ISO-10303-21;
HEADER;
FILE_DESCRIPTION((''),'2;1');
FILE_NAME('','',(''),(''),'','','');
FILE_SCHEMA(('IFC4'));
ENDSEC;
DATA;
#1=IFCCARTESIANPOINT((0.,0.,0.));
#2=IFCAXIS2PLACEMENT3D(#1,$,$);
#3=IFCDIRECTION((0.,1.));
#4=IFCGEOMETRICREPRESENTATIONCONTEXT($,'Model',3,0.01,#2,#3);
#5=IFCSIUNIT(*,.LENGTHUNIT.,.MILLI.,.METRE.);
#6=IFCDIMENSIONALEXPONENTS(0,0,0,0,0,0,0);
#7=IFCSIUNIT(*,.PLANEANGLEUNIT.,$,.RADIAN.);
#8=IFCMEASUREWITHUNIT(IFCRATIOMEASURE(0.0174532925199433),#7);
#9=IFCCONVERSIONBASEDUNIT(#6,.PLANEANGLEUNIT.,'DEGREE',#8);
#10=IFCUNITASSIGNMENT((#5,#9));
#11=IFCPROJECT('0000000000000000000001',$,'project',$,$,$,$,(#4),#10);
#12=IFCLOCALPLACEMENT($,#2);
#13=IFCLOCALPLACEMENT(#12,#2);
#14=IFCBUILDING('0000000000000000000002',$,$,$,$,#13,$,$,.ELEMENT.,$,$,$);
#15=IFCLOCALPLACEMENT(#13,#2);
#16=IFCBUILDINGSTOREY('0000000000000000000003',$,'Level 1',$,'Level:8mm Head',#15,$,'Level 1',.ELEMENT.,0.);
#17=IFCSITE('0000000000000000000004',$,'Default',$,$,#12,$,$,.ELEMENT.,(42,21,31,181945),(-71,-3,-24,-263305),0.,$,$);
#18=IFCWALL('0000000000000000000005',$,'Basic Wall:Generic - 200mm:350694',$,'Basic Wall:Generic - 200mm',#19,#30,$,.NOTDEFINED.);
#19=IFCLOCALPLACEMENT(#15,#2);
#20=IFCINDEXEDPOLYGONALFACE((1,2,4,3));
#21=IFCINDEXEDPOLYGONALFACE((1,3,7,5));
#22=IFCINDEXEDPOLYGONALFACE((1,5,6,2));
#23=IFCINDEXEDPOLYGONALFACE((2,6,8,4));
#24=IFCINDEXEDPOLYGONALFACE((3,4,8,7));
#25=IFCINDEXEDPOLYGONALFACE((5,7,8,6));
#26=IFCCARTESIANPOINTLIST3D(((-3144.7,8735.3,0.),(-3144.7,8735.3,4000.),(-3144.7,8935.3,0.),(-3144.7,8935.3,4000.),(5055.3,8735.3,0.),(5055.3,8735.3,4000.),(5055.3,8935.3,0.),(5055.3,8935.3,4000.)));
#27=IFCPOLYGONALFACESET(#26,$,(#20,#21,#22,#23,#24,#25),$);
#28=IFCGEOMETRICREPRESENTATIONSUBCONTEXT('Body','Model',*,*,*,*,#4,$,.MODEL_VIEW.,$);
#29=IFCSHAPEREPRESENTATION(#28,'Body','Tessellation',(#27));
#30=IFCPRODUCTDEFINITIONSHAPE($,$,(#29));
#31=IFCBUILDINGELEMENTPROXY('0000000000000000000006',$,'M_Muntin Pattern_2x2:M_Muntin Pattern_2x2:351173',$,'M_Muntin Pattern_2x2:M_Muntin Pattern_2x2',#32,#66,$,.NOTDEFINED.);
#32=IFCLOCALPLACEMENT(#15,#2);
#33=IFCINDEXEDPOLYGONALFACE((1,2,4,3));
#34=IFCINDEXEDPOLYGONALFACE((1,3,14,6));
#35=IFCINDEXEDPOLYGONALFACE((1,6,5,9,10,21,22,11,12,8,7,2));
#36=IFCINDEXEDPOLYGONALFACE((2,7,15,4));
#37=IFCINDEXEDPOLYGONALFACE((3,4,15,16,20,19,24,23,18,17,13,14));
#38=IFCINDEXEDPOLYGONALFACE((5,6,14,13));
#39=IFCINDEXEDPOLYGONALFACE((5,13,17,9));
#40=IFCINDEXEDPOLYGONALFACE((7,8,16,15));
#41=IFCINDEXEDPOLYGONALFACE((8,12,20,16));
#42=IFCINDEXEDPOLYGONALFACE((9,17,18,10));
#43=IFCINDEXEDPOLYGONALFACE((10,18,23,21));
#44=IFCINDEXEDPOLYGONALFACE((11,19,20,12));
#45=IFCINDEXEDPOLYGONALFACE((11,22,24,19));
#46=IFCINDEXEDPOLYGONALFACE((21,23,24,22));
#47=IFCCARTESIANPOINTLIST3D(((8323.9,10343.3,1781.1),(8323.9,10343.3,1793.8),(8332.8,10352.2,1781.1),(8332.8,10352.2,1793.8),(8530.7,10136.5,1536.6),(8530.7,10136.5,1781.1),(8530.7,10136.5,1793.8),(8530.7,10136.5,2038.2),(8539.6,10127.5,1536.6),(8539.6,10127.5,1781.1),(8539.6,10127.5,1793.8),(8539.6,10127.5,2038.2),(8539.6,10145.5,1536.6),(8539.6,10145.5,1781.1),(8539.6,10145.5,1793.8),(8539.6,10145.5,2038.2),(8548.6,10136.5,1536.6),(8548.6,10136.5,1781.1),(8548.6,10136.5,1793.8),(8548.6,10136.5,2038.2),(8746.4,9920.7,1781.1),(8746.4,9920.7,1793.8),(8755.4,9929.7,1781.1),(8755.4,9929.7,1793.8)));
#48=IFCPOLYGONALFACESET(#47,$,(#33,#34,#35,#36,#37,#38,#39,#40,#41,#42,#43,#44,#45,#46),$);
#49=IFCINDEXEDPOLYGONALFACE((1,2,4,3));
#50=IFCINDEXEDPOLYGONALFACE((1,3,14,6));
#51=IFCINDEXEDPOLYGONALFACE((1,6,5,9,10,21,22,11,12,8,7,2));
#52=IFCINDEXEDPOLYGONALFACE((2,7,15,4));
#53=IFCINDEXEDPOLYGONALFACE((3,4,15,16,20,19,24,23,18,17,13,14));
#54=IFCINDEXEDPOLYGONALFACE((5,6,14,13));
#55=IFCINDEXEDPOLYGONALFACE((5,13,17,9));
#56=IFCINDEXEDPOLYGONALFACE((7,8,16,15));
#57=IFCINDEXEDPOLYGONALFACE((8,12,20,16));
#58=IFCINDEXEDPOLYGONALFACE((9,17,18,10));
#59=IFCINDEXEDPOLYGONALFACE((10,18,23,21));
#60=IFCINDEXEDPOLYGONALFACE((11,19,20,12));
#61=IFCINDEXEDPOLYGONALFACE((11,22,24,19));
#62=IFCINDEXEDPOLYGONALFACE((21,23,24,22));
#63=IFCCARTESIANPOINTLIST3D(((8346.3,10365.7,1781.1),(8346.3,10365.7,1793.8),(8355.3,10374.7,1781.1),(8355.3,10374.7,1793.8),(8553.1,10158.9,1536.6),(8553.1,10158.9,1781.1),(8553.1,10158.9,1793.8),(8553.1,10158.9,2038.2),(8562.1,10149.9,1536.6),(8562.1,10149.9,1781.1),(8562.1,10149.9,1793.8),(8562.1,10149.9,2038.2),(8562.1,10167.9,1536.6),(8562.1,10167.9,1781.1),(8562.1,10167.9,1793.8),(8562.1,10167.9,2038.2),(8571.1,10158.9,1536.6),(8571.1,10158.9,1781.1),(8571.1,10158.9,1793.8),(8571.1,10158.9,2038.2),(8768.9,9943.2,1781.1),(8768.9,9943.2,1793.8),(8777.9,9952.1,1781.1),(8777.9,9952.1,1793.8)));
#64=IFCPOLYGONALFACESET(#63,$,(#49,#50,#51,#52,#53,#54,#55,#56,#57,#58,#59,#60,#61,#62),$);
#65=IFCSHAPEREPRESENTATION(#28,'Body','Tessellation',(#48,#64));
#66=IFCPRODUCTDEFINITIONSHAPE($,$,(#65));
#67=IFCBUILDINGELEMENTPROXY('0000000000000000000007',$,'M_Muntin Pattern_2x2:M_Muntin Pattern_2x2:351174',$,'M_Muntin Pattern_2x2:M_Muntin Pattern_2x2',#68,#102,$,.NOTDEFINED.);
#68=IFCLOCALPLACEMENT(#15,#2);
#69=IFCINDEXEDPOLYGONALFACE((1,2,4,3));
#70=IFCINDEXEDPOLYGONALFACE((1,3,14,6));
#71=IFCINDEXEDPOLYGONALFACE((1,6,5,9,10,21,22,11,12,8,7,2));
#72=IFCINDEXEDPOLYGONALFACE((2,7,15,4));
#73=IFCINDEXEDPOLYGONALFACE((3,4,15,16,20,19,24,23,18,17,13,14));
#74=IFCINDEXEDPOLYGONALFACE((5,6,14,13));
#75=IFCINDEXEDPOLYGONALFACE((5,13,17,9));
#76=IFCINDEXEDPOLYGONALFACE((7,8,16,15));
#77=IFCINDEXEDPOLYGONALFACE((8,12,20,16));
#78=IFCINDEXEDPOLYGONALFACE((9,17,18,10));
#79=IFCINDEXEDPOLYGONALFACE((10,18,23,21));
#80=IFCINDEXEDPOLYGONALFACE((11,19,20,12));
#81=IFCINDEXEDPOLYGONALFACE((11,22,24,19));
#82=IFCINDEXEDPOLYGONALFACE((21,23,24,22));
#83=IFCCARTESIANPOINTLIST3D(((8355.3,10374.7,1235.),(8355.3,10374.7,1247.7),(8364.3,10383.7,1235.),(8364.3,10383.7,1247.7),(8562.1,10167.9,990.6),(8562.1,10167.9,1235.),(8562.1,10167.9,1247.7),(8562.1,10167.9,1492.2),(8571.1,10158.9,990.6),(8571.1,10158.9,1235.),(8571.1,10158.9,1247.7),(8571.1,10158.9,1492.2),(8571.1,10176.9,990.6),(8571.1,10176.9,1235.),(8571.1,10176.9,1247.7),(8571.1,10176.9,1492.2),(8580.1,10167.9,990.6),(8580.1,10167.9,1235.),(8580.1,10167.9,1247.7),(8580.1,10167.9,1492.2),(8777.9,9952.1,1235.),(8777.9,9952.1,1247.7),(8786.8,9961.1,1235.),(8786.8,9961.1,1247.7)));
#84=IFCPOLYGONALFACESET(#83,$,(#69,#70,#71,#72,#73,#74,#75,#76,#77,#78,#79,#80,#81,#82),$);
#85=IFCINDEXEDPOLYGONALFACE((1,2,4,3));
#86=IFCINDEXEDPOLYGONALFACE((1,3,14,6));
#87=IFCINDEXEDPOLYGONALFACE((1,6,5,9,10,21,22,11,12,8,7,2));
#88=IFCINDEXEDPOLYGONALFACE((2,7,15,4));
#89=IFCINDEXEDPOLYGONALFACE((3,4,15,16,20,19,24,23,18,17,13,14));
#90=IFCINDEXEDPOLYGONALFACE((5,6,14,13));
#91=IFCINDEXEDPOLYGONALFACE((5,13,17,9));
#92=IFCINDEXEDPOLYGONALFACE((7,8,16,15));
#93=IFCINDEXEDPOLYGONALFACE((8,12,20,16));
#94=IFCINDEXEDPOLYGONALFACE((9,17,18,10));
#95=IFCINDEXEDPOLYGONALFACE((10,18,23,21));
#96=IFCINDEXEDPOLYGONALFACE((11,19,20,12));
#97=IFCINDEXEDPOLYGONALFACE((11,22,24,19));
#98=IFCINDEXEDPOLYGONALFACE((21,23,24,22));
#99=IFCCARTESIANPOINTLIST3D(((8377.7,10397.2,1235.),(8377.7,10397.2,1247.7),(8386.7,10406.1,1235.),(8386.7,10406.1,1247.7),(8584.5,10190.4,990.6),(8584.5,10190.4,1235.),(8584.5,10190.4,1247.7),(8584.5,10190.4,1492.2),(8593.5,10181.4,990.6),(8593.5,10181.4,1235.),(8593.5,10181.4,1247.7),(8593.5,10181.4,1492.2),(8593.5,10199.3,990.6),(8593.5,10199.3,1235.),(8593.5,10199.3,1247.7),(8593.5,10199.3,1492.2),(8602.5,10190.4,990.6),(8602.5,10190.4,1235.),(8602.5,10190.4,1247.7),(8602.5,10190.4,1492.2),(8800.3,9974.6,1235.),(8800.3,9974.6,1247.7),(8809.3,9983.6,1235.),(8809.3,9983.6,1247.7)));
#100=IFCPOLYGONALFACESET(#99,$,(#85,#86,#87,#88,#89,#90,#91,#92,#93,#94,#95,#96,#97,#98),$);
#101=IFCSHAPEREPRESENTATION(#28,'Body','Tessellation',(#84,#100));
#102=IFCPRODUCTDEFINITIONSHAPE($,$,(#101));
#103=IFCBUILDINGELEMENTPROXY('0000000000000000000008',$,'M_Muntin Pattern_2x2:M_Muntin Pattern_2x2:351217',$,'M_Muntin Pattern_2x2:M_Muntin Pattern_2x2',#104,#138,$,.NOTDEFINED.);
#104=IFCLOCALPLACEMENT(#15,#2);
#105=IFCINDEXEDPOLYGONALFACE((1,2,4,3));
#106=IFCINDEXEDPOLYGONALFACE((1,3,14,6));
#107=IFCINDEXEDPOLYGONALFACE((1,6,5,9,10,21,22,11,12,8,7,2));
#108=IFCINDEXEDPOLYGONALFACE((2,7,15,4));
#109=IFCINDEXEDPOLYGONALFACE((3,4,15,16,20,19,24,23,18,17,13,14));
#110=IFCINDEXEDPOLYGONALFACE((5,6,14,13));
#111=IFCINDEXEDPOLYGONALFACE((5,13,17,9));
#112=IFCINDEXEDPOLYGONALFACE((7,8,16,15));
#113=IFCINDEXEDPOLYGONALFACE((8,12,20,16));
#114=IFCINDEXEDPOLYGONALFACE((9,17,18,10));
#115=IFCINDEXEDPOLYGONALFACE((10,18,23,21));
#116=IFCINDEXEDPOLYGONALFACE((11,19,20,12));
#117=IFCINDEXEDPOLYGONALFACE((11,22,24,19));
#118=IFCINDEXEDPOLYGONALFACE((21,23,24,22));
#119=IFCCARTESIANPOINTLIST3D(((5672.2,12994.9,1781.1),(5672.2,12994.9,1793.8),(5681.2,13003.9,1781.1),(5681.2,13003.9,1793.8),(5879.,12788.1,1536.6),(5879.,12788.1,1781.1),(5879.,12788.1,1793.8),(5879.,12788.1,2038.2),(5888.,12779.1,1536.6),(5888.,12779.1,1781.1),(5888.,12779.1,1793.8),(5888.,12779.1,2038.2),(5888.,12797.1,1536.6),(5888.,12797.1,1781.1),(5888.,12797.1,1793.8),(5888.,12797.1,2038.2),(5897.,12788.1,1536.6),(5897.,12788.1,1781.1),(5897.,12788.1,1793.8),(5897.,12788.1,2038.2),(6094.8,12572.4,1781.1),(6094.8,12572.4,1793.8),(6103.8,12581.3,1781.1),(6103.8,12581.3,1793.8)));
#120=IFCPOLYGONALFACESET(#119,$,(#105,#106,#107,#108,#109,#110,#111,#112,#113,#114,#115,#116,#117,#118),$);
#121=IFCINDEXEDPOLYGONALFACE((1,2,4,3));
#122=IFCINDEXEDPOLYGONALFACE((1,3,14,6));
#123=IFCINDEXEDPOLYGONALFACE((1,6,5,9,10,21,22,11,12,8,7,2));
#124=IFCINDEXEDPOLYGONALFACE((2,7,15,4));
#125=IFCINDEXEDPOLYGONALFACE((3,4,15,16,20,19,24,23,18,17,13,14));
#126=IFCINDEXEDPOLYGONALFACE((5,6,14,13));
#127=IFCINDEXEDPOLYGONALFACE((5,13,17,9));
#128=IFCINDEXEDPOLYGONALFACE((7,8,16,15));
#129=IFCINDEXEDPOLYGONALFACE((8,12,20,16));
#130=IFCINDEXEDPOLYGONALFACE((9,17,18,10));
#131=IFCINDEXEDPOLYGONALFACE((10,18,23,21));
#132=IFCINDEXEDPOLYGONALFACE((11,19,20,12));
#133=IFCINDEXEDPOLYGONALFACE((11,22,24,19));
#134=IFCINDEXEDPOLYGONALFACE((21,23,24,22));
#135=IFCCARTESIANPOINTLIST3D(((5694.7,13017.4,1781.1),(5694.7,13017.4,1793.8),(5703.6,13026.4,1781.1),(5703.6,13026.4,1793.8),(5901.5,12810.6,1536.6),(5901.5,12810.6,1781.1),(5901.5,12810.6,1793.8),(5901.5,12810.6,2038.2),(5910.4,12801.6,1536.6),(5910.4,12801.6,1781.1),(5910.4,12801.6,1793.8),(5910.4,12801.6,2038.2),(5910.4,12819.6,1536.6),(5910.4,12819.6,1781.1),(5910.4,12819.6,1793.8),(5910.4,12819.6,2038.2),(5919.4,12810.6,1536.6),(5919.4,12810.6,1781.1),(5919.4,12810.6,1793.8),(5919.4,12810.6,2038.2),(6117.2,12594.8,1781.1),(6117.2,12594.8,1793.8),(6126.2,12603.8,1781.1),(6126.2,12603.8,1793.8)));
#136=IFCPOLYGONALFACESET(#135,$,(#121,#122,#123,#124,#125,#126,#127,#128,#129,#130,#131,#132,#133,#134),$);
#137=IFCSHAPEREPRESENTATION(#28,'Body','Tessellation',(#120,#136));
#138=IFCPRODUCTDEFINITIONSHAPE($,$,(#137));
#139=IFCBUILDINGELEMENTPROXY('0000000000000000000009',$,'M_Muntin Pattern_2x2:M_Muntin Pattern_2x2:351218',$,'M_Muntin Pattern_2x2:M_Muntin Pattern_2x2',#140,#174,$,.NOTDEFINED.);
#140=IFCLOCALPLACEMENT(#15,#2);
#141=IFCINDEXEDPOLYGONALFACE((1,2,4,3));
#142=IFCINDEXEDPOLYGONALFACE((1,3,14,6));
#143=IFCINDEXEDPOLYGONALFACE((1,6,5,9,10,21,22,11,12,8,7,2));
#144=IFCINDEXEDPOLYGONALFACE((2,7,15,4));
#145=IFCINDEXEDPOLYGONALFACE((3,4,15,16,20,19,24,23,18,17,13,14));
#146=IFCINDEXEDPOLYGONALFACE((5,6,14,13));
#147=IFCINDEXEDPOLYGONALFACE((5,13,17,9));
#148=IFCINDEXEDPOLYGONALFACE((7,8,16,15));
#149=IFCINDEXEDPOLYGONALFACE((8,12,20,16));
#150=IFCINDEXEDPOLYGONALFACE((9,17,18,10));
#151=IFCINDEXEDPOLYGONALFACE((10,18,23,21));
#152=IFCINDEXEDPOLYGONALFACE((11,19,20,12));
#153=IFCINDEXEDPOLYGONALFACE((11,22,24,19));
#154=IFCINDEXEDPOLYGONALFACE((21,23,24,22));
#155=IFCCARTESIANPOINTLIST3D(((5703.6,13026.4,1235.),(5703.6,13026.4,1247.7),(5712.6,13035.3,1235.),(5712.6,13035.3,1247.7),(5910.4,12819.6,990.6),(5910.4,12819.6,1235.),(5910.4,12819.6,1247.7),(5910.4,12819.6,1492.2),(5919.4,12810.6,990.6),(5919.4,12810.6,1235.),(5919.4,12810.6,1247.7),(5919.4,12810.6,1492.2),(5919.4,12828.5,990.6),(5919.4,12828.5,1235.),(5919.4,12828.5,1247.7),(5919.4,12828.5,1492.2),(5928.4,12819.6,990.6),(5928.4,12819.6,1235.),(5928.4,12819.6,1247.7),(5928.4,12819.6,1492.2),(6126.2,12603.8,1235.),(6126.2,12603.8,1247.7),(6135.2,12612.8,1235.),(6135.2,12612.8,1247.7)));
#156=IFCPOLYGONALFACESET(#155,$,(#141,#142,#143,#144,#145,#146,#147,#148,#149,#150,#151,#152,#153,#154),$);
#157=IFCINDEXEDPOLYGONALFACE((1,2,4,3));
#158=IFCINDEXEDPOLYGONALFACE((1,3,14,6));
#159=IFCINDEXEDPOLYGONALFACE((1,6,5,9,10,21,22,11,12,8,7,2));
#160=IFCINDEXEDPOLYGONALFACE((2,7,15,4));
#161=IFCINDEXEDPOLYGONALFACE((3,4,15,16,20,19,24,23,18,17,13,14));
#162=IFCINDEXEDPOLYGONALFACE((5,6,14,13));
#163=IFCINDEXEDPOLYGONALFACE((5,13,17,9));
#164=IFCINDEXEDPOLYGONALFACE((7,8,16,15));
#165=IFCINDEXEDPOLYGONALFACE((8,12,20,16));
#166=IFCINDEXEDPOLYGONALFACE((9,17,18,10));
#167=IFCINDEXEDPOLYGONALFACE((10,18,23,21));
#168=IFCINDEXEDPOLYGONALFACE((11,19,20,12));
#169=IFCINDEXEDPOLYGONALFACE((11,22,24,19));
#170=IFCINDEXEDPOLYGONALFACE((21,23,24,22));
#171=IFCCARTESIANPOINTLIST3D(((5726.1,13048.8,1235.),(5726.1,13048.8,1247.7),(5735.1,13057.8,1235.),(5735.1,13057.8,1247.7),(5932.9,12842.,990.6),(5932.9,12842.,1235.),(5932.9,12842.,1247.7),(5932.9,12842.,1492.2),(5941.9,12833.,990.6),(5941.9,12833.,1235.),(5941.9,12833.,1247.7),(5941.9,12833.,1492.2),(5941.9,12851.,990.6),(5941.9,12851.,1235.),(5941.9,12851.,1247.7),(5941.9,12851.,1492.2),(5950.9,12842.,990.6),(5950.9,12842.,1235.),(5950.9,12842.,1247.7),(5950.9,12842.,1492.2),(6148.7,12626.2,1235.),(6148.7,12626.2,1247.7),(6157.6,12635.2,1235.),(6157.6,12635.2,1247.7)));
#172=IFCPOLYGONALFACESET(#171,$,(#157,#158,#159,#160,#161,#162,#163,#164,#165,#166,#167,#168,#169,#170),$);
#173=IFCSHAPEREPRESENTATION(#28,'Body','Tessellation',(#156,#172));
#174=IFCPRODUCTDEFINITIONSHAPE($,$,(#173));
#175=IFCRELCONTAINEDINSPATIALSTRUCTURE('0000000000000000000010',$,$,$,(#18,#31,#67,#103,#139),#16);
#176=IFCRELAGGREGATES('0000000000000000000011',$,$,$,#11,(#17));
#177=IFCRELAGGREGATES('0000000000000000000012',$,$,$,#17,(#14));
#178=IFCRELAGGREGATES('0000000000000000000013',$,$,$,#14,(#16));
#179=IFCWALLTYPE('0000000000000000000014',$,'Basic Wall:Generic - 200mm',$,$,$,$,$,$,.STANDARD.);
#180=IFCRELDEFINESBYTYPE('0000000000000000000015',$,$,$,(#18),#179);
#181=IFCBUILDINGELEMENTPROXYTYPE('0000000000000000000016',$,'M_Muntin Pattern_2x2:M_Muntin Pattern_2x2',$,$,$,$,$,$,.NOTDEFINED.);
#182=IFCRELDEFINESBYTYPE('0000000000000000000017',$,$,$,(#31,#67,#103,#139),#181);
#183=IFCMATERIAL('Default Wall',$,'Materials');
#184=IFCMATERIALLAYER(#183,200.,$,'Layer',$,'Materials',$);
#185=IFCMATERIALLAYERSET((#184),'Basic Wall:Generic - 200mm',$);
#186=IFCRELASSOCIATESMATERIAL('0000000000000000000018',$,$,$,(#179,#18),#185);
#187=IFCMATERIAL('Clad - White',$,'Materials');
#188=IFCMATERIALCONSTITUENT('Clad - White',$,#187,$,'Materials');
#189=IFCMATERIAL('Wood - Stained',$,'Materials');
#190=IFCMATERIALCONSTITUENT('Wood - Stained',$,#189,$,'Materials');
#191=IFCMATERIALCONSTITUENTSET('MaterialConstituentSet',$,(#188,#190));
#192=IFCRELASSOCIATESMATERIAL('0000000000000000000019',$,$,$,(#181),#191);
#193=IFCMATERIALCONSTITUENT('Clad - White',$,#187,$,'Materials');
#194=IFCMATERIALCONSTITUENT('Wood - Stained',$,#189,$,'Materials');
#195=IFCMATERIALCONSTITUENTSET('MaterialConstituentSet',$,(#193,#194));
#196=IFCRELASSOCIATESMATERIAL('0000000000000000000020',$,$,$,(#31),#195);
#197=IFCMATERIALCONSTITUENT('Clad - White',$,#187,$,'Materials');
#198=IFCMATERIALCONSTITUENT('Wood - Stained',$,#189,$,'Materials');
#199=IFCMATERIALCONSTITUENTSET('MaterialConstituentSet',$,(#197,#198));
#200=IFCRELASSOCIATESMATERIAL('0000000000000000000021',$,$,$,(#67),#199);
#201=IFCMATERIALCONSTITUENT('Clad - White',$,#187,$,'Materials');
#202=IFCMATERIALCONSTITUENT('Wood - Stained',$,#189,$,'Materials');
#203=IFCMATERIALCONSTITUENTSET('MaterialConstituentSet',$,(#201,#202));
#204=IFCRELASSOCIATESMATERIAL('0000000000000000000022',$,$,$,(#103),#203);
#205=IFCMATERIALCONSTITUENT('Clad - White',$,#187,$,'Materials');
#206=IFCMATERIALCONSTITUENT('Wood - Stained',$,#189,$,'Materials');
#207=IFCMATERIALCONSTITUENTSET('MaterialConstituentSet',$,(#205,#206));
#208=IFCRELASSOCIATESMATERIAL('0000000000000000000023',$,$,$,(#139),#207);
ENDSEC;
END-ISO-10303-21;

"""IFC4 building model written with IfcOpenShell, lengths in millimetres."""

from ifc_helpers import new_model, entity, si_unit, converted_unit, direction, frame, frame_2d, origin, place, context, subcontext, project, spatial, polyline, rectangle, outline, extrude, source, transform, mapped, material, layer, layer_set, layer_usage, constituent, constituent_set, type_object, type_shapes, element, save


model = new_model("IFC4")

# Units and contexts
model_context = context("Model", 3, precision=0.01, world=origin(), true_north=direction((0.0, 1.0)))
body_context = subcontext(model_context, "Body", "Model", "MODEL_VIEW")
ifc_project = project(units=[si_unit("LENGTHUNIT", "METRE", prefix="MILLI"), converted_unit("PLANEANGLEUNIT", "DEGREE", entity("IfcRatioMeasure", 0.0174532925199433), si_unit("PLANEANGLEUNIT", "RADIAN"), dimensions=[0, 0, 0, 0, 0, 0, 0])], contexts=[model_context])

# Site, building, storey
site_placement = place(None, origin())
site = spatial("IfcSite", under=ifc_project, at=site_placement, Name="Default", CompositionType="ELEMENT", RefLatitude=(42, 21, 31, 181945), RefLongitude=(-71, -3, -24, -263305), RefElevation=0.0)
building_placement = place(site_placement, origin())
building = spatial("IfcBuilding", under=site, at=building_placement, CompositionType="ELEMENT")
storey_placement = place(building_placement, origin())
storey = spatial("IfcBuildingStorey", under=building, at=storey_placement, Name="Level 1", ObjectType="Level:8mm Head", LongName="Level 1", CompositionType="ELEMENT", Elevation=0.0)

# Shared definitions
ifc_material_1 = material(Name="Default Wall", Category="Materials")
ifc_layer = layer(ifc_material_1, 200.0, Name="Layer", Category="Materials")
ifc_layer_set = layer_set([ifc_layer], Name="Basic Wall:Generic - 200mm")
wall_type = type_object("IfcWallType", Name="Basic Wall:Generic - 200mm", PredefinedType="STANDARD", material=ifc_layer_set)
ifc_material_2 = material(Name="Wood - Stained", Category="Materials")

# Wall
ifc_layer_usage_1 = layer_usage(ifc_layer_set, "AXIS2", "NEGATIVE", 100.0)
wall_1_placement = place(storey_placement, frame((5055.3, 8835.3, 0.0), z_axis=(0.0, 0.0, 1.0), x_axis=(-1.0, 0.0, 0.0)))
element("IfcWall", 1, at=wall_1_placement, inside=storey, type_object=wall_type, material=ifc_layer_usage_1, Name="Basic Wall:Generic - 200mm:350694", ObjectType="Basic Wall:Generic - 200mm", PredefinedType="NOTDEFINED", context=body_context, shape_type="SweptSolid", body=[
    extrude(rectangle(XDim=8200.0, YDim=200.0, at=frame_2d((4100.0, 0.0), x_axis=(-1.0, 0.0))), origin(), (0.0, 0.0, 1.0), 4000.0),
])

# Building element proxies
ifc_material_3 = material(Name="Clad - White", Category="Materials")
ifc_constituent_1 = constituent(ifc_material_3, Name="Clad - White", Category="Materials")
ifc_constituent_2 = constituent(ifc_material_2, Name="Wood - Stained", Category="Materials")
ifc_constituent_set_1 = constituent_set(constituents=[ifc_constituent_1, ifc_constituent_2], Name="MaterialConstituentSet")
ifc_constituent_3 = constituent(ifc_material_3, Name="Clad - White", Category="Materials")
ifc_constituent_4 = constituent(ifc_material_2, Name="Wood - Stained", Category="Materials")
ifc_constituent_set_2 = constituent_set(constituents=[ifc_constituent_3, ifc_constituent_4], Name="MaterialConstituentSet")
building_element_proxy_type_1 = type_object("IfcBuildingElementProxyType", Name="M_Muntin Pattern_2x2:M_Muntin Pattern_2x2", PredefinedType="NOTDEFINED", material=ifc_constituent_set_2)
shared_shape_1 = source(origin(), body_context, "Body", "SweptSolid", [
    extrude(outline(polyline([(6.4, -6.4), (250.8, -6.4), (250.8, 6.3), (6.4, 6.3), (6.4, 298.8), (-6.3, 298.8), (-6.3, 6.3), (-250.8, 6.3), (-250.8, -6.4), (-6.3, -6.4), (-6.3, -298.8), (6.4, -298.8), (6.4, -6.4)])), frame((0.0, 9.5, 250.8), z_axis=(0.0, 1.0, 0.0), x_axis=(0.0, 0.0, 1.0)), (0.0, 0.0, 1.0), 12.7),
    extrude(outline(polyline([(6.4, -6.4), (250.8, -6.4), (250.8, 6.3), (6.4, 6.3), (6.4, 298.8), (-6.3, 298.8), (-6.3, 6.3), (-250.8, 6.3), (-250.8, -6.4), (-6.3, -6.4), (-6.3, -298.8), (6.4, -298.8), (6.4, -6.4)])), frame((0.0, -22.2, 250.8), z_axis=(0.0, 1.0, 0.0), x_axis=(0.0, 0.0, 1.0)), (0.0, 0.0, 1.0), 12.7),
])
type_shapes(building_element_proxy_type_1, [shared_shape_1])
proxy_1_placement = place(storey_placement, frame((8550.9, 10147.7, 1536.6), z_axis=(0.0, 0.0, 1.0), x_axis=(-0.707107, 0.707107, 0.0)))
element("IfcBuildingElementProxy", 2, at=proxy_1_placement, inside=storey, type_object=building_element_proxy_type_1, material=ifc_constituent_set_1, Name="M_Muntin Pattern_2x2:M_Muntin Pattern_2x2:351173", ObjectType="M_Muntin Pattern_2x2:M_Muntin Pattern_2x2", PredefinedType="NOTDEFINED", context=body_context, shape_type="MappedRepresentation", body=[
    mapped(shared_shape_1, transform((0.0, 0.0, 0.0), scale=1.0)),
])
ifc_constituent_5 = constituent(ifc_material_3, Name="Clad - White", Category="Materials")
ifc_constituent_6 = constituent(ifc_material_2, Name="Wood - Stained", Category="Materials")
ifc_constituent_set_3 = constituent_set(constituents=[ifc_constituent_5, ifc_constituent_6], Name="MaterialConstituentSet")
proxy_2_placement = place(storey_placement, frame((8582.3, 10179.1, 990.6), z_axis=(0.0, 0.0, 1.0), x_axis=(-0.707107, 0.707107, 0.0)))
element("IfcBuildingElementProxy", 3, at=proxy_2_placement, inside=storey, type_object=building_element_proxy_type_1, material=ifc_constituent_set_3, Name="M_Muntin Pattern_2x2:M_Muntin Pattern_2x2:351174", ObjectType="M_Muntin Pattern_2x2:M_Muntin Pattern_2x2", PredefinedType="NOTDEFINED", context=body_context, shape_type="MappedRepresentation", body=[
    mapped(shared_shape_1, transform((0.0, 0.0, 0.0), scale=1.0)),
])
ifc_constituent_7 = constituent(ifc_material_3, Name="Clad - White", Category="Materials")
ifc_constituent_8 = constituent(ifc_material_2, Name="Wood - Stained", Category="Materials")
ifc_constituent_set_4 = constituent_set(constituents=[ifc_constituent_7, ifc_constituent_8], Name="MaterialConstituentSet")
proxy_3_placement = place(storey_placement, frame((5899.2, 12799.4, 1536.6), z_axis=(0.0, 0.0, 1.0), x_axis=(-0.707107, 0.707107, 0.0)))
element("IfcBuildingElementProxy", 4, at=proxy_3_placement, inside=storey, type_object=building_element_proxy_type_1, material=ifc_constituent_set_4, Name="M_Muntin Pattern_2x2:M_Muntin Pattern_2x2:351217", ObjectType="M_Muntin Pattern_2x2:M_Muntin Pattern_2x2", PredefinedType="NOTDEFINED", context=body_context, shape_type="MappedRepresentation", body=[
    mapped(shared_shape_1, transform((0.0, 0.0, 0.0), scale=1.0)),
])
ifc_constituent_9 = constituent(ifc_material_3, Name="Clad - White", Category="Materials")
ifc_constituent_10 = constituent(ifc_material_2, Name="Wood - Stained", Category="Materials")
ifc_constituent_set_5 = constituent_set(constituents=[ifc_constituent_9, ifc_constituent_10], Name="MaterialConstituentSet")
proxy_4_placement = place(storey_placement, frame((5930.6, 12830.8, 990.6), z_axis=(0.0, 0.0, 1.0), x_axis=(-0.707107, 0.707107, 0.0)))
element("IfcBuildingElementProxy", 5, at=proxy_4_placement, inside=storey, type_object=building_element_proxy_type_1, material=ifc_constituent_set_5, Name="M_Muntin Pattern_2x2:M_Muntin Pattern_2x2:351218", ObjectType="M_Muntin Pattern_2x2:M_Muntin Pattern_2x2", PredefinedType="NOTDEFINED", context=body_context, shape_type="MappedRepresentation", body=[
    mapped(shared_shape_1, transform((0.0, 0.0, 0.0), scale=1.0)),
])

save(model, "model.ifc")
